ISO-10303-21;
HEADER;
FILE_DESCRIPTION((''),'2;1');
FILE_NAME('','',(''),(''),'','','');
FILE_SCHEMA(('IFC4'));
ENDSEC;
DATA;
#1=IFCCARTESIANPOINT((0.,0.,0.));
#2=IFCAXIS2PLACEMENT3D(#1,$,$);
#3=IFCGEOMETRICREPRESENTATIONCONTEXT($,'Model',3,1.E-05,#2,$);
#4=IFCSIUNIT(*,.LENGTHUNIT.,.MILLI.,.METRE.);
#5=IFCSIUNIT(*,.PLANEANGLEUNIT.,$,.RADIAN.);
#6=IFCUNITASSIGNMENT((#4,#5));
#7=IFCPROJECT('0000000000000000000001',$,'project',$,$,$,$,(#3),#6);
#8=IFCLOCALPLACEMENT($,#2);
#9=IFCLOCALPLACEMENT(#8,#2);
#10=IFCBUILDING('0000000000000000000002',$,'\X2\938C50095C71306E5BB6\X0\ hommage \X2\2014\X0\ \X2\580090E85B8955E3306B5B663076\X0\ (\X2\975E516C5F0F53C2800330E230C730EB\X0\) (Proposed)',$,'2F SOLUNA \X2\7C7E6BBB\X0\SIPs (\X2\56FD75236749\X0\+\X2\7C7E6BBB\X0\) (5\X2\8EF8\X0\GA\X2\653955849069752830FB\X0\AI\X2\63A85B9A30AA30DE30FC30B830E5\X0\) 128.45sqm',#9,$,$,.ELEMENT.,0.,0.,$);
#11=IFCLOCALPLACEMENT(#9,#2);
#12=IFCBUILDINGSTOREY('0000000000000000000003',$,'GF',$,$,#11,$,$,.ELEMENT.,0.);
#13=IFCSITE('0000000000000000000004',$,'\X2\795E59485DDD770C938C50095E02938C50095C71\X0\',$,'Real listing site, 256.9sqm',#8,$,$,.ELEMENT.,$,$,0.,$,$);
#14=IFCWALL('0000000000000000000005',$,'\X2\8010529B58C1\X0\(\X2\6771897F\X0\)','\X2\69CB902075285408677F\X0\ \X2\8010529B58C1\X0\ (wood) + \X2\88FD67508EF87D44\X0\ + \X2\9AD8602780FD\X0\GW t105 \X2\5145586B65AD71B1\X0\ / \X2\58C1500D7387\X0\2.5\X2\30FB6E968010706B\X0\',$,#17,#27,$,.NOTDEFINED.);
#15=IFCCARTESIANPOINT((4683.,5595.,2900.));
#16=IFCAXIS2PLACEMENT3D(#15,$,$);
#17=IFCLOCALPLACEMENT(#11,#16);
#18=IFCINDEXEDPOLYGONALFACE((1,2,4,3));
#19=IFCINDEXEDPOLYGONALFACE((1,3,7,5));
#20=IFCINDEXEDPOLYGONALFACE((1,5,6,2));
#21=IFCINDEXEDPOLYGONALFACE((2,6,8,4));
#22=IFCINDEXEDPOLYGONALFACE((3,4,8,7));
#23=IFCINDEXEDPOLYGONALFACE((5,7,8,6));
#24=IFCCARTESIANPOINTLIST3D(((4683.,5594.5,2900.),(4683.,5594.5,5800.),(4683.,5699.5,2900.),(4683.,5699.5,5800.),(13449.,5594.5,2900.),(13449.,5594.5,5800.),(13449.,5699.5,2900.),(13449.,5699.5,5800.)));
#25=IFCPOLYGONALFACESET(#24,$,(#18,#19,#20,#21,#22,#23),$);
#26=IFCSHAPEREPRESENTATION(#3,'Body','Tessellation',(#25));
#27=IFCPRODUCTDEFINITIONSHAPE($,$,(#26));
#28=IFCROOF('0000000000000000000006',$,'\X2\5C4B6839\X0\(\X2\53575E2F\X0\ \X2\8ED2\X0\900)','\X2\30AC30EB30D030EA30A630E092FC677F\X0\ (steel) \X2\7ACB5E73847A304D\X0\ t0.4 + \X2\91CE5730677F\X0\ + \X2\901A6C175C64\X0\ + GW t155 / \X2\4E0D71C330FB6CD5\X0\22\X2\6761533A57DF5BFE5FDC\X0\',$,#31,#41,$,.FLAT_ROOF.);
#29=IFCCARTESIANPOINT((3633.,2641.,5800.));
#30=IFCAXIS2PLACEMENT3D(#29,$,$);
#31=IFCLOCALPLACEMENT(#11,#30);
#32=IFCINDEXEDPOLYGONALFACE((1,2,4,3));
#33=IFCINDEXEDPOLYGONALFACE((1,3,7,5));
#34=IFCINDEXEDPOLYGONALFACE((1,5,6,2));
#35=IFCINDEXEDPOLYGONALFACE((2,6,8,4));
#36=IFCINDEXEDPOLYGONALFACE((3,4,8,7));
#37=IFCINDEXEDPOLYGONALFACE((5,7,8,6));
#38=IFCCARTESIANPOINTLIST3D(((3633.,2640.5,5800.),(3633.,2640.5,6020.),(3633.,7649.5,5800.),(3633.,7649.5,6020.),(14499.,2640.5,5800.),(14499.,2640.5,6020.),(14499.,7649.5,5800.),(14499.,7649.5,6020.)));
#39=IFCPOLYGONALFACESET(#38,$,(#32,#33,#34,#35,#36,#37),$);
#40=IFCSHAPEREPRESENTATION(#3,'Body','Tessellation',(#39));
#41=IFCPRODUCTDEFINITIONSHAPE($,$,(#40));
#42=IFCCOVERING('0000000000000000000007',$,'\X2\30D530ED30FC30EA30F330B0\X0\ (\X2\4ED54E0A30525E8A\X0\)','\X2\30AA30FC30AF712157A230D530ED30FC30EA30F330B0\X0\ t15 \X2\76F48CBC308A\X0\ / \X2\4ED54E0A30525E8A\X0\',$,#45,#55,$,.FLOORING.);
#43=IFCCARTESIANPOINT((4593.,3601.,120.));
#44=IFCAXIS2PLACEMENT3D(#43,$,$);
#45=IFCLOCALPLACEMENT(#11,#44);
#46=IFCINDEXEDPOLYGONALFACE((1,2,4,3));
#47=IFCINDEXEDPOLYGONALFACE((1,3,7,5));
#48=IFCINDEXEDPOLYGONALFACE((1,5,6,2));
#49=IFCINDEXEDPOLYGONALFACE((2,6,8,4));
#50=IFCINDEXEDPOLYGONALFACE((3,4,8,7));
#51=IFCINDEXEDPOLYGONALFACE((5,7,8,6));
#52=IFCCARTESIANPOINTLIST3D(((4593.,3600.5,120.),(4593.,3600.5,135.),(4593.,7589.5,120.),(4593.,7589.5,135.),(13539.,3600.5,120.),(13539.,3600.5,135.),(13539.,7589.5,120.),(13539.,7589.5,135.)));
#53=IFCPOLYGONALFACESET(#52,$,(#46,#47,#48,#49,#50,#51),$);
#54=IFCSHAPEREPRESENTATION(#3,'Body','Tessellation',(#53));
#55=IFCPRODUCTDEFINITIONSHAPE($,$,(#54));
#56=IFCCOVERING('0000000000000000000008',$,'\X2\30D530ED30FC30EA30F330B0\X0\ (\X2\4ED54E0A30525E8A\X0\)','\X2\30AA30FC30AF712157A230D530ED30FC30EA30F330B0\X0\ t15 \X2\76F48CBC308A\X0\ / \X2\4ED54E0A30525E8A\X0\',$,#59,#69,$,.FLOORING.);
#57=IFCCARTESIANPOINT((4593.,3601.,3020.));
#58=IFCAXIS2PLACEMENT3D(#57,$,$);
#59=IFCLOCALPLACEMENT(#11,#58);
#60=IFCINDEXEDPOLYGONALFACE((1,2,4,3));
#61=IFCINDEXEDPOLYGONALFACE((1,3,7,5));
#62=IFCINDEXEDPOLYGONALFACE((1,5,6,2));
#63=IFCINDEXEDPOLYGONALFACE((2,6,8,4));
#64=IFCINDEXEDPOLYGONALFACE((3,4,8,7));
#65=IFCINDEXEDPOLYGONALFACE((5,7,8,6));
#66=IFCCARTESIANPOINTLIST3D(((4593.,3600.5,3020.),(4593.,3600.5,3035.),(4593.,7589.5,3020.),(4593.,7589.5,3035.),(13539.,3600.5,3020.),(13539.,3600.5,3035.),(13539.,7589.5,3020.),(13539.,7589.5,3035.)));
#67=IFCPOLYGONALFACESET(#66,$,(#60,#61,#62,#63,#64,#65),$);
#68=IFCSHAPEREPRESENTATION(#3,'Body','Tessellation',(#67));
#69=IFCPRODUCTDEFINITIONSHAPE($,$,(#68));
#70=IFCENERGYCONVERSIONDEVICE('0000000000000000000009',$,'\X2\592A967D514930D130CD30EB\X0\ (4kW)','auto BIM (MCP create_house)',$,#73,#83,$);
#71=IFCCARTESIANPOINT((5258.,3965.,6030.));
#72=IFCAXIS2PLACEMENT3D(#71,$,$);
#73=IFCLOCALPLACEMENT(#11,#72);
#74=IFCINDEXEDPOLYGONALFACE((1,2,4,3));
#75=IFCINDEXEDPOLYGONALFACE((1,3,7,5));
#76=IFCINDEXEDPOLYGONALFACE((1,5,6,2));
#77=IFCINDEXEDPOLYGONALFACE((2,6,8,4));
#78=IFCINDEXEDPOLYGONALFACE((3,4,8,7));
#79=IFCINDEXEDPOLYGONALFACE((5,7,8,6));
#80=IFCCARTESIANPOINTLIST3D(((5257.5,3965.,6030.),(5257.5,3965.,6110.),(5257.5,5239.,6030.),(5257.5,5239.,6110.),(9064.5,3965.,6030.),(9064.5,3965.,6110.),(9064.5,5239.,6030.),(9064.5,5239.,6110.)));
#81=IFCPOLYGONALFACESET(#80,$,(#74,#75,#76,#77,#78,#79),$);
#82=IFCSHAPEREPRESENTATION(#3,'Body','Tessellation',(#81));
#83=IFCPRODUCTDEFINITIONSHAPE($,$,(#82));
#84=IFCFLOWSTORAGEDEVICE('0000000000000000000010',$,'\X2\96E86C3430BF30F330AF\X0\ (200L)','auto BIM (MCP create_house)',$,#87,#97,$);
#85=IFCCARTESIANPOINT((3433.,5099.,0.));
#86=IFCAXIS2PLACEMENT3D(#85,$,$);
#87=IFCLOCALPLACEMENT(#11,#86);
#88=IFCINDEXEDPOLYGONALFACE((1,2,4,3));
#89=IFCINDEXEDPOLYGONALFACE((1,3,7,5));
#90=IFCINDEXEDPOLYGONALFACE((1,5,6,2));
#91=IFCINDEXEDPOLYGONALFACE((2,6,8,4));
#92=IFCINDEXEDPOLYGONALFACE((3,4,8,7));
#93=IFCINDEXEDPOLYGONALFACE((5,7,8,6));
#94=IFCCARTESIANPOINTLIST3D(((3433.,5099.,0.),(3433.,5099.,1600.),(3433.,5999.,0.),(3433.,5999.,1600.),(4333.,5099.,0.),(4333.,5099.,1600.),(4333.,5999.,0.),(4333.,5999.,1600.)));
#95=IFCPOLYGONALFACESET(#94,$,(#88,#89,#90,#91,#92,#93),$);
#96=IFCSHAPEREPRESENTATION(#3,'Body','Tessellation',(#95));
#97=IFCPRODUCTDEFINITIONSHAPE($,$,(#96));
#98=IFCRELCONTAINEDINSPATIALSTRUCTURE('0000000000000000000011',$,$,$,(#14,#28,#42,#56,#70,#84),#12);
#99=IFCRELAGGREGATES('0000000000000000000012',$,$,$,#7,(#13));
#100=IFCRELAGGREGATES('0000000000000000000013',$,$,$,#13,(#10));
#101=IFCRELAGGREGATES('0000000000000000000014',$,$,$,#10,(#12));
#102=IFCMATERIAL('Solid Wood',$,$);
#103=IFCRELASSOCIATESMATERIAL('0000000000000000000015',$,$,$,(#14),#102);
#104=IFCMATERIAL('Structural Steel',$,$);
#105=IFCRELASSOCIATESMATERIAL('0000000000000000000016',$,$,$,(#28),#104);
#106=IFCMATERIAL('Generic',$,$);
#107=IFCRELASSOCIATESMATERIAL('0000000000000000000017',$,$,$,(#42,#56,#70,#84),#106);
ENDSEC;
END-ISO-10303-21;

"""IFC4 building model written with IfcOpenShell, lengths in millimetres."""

from ifc_helpers import new_model, si_unit, frame, frame_2d, origin, place, context, project, spatial, rectangle, extrude, material, element, save


model = new_model("IFC4")

# Units and contexts
model_context = context("Model", 3, precision=1e-05, world=origin())
ifc_project = project(units=[si_unit("LENGTHUNIT", "METRE", prefix="MILLI"), si_unit("PLANEANGLEUNIT", "RADIAN")], contexts=[model_context])

# Site, building, storey
site_placement = place(None, origin())
site = spatial("IfcSite", under=ifc_project, at=site_placement, Name="神奈川県鎌倉市鎌倉山", ObjectType="Real listing site, 256.9sqm", CompositionType="ELEMENT", RefElevation=0.0)
building_placement = place(site_placement, origin())
building = spatial("IfcBuilding", under=site, at=building_placement, Name="鎌倉山の家 hommage — 堀部安嗣に学ぶ (非公式参考モデル) (Proposed)", ObjectType="2F SOLUNA 籾殻SIPs (国産杉+籾殻) (5軸GA改善適用・AI推定オマージュ) 128.45sqm", CompositionType="ELEMENT", ElevationOfRefHeight=0.0, ElevationOfTerrain=0.0)
storey_placement = place(building_placement, origin())
storey = spatial("IfcBuildingStorey", under=building, at=storey_placement, Name="GF", CompositionType="ELEMENT", Elevation=0.0)

# Shared definitions
ifc_material_1 = material(Name="Solid Wood")

# Wall
wall_1_placement = place(storey_placement, frame((4683.0, 5595.0, 2900.0)))
element("IfcWall", 1, at=wall_1_placement, inside=storey, material=ifc_material_1, Name="耐力壁(東西)", Description="構造用合板 耐力壁 (wood) + 製材軸組 + 高性能GW t105 充填断熱 / 壁倍率2.5・準耐火", PredefinedType="NOTDEFINED", context=model_context, shape_type="SweptSolid", body=[
    extrude(rectangle(XDim=8766.0, YDim=105.0, at=frame_2d((4383.0, 52.0))), frame((4683.0, 5595.0, 2900.0)), (0.0, 0.0, 1.0), 2900.0),
])

# Roof
ifc_material_2 = material(Name="Structural Steel")
for number, where, name in (
    (2, (3633.0, 2641.0, 5800.0), "屋根(南帯 軒900)"),
):
    element("IfcRoof", number, at=place(storey_placement, frame(where)), inside=storey, material=ifc_material_2, Name=name, Description="ガルバリウム鋼板 (steel) 立平葺き t0.4 + 野地板 + 通気層 + GW t155 / 不燃・法22条区域対応", PredefinedType="FLAT_ROOF", context=model_context, shape_type="SweptSolid", body=[
        extrude(rectangle(XDim=10866.0, YDim=5009.0, at=frame_2d((5433.0, 2504.0))), frame((3633.0, 2641.0, 5800.0)), (0.0, 0.0, 1.0), 220.0),
    ])

# Coverings
ifc_material_3 = material(Name="Generic")
covering_1_placement = place(storey_placement, frame((4593.0, 3601.0, 120.0)))
element("IfcCovering", 3, at=covering_1_placement, inside=storey, material=ifc_material_3, Name="フローリング (仕上げ床)", Description="オーク無垢フローリング t15 直貼り / 仕上げ床", PredefinedType="FLOORING", context=model_context, shape_type="SweptSolid", body=[
    extrude(rectangle(XDim=8946.0, YDim=3989.0, at=frame_2d((4473.0, 1994.0))), frame((4593.0, 3601.0, 120.0)), (0.0, 0.0, 1.0), 15.0),
])
covering_2_placement = place(storey_placement, frame((4593.0, 3601.0, 3020.0)))
element("IfcCovering", 4, at=covering_2_placement, inside=storey, material=ifc_material_3, Name="フローリング (仕上げ床)", Description="オーク無垢フローリング t15 直貼り / 仕上げ床", PredefinedType="FLOORING", context=model_context, shape_type="SweptSolid", body=[
    extrude(rectangle(XDim=8946.0, YDim=3989.0, at=frame_2d((4473.0, 1994.0))), frame((4593.0, 3601.0, 3020.0)), (0.0, 0.0, 1.0), 15.0),
])

# Energy conversion device
energy_conversion_device_placement = place(storey_placement, frame((5258.0, 3965.0, 6030.0)))
element("IfcEnergyConversionDevice", 5, at=energy_conversion_device_placement, inside=storey, material=ifc_material_3, Name="太陽光パネル (4kW)", Description="auto BIM (MCP create_house)", context=model_context, shape_type="SweptSolid", body=[
    extrude(rectangle(XDim=3807.0, YDim=1274.0, at=frame_2d((1903.0, 637.0))), frame((5258.0, 3965.0, 6030.0)), (0.0, 0.0, 1.0), 80.0),
])

# Flow storage device
flow_storage_device_placement = place(storey_placement, frame((3433.0, 5099.0, 0.0)))
element("IfcFlowStorageDevice", 6, at=flow_storage_device_placement, inside=storey, material=ifc_material_3, Name="雨水タンク (200L)", Description="auto BIM (MCP create_house)", context=model_context, shape_type="SweptSolid", body=[
    extrude(rectangle(XDim=900.0, YDim=900.0, at=frame_2d((450.0, 450.0))), frame((3433.0, 5099.0, 0.0)), (0.0, 0.0, 1.0), 1600.0),
])

save(model, "model.ifc")
